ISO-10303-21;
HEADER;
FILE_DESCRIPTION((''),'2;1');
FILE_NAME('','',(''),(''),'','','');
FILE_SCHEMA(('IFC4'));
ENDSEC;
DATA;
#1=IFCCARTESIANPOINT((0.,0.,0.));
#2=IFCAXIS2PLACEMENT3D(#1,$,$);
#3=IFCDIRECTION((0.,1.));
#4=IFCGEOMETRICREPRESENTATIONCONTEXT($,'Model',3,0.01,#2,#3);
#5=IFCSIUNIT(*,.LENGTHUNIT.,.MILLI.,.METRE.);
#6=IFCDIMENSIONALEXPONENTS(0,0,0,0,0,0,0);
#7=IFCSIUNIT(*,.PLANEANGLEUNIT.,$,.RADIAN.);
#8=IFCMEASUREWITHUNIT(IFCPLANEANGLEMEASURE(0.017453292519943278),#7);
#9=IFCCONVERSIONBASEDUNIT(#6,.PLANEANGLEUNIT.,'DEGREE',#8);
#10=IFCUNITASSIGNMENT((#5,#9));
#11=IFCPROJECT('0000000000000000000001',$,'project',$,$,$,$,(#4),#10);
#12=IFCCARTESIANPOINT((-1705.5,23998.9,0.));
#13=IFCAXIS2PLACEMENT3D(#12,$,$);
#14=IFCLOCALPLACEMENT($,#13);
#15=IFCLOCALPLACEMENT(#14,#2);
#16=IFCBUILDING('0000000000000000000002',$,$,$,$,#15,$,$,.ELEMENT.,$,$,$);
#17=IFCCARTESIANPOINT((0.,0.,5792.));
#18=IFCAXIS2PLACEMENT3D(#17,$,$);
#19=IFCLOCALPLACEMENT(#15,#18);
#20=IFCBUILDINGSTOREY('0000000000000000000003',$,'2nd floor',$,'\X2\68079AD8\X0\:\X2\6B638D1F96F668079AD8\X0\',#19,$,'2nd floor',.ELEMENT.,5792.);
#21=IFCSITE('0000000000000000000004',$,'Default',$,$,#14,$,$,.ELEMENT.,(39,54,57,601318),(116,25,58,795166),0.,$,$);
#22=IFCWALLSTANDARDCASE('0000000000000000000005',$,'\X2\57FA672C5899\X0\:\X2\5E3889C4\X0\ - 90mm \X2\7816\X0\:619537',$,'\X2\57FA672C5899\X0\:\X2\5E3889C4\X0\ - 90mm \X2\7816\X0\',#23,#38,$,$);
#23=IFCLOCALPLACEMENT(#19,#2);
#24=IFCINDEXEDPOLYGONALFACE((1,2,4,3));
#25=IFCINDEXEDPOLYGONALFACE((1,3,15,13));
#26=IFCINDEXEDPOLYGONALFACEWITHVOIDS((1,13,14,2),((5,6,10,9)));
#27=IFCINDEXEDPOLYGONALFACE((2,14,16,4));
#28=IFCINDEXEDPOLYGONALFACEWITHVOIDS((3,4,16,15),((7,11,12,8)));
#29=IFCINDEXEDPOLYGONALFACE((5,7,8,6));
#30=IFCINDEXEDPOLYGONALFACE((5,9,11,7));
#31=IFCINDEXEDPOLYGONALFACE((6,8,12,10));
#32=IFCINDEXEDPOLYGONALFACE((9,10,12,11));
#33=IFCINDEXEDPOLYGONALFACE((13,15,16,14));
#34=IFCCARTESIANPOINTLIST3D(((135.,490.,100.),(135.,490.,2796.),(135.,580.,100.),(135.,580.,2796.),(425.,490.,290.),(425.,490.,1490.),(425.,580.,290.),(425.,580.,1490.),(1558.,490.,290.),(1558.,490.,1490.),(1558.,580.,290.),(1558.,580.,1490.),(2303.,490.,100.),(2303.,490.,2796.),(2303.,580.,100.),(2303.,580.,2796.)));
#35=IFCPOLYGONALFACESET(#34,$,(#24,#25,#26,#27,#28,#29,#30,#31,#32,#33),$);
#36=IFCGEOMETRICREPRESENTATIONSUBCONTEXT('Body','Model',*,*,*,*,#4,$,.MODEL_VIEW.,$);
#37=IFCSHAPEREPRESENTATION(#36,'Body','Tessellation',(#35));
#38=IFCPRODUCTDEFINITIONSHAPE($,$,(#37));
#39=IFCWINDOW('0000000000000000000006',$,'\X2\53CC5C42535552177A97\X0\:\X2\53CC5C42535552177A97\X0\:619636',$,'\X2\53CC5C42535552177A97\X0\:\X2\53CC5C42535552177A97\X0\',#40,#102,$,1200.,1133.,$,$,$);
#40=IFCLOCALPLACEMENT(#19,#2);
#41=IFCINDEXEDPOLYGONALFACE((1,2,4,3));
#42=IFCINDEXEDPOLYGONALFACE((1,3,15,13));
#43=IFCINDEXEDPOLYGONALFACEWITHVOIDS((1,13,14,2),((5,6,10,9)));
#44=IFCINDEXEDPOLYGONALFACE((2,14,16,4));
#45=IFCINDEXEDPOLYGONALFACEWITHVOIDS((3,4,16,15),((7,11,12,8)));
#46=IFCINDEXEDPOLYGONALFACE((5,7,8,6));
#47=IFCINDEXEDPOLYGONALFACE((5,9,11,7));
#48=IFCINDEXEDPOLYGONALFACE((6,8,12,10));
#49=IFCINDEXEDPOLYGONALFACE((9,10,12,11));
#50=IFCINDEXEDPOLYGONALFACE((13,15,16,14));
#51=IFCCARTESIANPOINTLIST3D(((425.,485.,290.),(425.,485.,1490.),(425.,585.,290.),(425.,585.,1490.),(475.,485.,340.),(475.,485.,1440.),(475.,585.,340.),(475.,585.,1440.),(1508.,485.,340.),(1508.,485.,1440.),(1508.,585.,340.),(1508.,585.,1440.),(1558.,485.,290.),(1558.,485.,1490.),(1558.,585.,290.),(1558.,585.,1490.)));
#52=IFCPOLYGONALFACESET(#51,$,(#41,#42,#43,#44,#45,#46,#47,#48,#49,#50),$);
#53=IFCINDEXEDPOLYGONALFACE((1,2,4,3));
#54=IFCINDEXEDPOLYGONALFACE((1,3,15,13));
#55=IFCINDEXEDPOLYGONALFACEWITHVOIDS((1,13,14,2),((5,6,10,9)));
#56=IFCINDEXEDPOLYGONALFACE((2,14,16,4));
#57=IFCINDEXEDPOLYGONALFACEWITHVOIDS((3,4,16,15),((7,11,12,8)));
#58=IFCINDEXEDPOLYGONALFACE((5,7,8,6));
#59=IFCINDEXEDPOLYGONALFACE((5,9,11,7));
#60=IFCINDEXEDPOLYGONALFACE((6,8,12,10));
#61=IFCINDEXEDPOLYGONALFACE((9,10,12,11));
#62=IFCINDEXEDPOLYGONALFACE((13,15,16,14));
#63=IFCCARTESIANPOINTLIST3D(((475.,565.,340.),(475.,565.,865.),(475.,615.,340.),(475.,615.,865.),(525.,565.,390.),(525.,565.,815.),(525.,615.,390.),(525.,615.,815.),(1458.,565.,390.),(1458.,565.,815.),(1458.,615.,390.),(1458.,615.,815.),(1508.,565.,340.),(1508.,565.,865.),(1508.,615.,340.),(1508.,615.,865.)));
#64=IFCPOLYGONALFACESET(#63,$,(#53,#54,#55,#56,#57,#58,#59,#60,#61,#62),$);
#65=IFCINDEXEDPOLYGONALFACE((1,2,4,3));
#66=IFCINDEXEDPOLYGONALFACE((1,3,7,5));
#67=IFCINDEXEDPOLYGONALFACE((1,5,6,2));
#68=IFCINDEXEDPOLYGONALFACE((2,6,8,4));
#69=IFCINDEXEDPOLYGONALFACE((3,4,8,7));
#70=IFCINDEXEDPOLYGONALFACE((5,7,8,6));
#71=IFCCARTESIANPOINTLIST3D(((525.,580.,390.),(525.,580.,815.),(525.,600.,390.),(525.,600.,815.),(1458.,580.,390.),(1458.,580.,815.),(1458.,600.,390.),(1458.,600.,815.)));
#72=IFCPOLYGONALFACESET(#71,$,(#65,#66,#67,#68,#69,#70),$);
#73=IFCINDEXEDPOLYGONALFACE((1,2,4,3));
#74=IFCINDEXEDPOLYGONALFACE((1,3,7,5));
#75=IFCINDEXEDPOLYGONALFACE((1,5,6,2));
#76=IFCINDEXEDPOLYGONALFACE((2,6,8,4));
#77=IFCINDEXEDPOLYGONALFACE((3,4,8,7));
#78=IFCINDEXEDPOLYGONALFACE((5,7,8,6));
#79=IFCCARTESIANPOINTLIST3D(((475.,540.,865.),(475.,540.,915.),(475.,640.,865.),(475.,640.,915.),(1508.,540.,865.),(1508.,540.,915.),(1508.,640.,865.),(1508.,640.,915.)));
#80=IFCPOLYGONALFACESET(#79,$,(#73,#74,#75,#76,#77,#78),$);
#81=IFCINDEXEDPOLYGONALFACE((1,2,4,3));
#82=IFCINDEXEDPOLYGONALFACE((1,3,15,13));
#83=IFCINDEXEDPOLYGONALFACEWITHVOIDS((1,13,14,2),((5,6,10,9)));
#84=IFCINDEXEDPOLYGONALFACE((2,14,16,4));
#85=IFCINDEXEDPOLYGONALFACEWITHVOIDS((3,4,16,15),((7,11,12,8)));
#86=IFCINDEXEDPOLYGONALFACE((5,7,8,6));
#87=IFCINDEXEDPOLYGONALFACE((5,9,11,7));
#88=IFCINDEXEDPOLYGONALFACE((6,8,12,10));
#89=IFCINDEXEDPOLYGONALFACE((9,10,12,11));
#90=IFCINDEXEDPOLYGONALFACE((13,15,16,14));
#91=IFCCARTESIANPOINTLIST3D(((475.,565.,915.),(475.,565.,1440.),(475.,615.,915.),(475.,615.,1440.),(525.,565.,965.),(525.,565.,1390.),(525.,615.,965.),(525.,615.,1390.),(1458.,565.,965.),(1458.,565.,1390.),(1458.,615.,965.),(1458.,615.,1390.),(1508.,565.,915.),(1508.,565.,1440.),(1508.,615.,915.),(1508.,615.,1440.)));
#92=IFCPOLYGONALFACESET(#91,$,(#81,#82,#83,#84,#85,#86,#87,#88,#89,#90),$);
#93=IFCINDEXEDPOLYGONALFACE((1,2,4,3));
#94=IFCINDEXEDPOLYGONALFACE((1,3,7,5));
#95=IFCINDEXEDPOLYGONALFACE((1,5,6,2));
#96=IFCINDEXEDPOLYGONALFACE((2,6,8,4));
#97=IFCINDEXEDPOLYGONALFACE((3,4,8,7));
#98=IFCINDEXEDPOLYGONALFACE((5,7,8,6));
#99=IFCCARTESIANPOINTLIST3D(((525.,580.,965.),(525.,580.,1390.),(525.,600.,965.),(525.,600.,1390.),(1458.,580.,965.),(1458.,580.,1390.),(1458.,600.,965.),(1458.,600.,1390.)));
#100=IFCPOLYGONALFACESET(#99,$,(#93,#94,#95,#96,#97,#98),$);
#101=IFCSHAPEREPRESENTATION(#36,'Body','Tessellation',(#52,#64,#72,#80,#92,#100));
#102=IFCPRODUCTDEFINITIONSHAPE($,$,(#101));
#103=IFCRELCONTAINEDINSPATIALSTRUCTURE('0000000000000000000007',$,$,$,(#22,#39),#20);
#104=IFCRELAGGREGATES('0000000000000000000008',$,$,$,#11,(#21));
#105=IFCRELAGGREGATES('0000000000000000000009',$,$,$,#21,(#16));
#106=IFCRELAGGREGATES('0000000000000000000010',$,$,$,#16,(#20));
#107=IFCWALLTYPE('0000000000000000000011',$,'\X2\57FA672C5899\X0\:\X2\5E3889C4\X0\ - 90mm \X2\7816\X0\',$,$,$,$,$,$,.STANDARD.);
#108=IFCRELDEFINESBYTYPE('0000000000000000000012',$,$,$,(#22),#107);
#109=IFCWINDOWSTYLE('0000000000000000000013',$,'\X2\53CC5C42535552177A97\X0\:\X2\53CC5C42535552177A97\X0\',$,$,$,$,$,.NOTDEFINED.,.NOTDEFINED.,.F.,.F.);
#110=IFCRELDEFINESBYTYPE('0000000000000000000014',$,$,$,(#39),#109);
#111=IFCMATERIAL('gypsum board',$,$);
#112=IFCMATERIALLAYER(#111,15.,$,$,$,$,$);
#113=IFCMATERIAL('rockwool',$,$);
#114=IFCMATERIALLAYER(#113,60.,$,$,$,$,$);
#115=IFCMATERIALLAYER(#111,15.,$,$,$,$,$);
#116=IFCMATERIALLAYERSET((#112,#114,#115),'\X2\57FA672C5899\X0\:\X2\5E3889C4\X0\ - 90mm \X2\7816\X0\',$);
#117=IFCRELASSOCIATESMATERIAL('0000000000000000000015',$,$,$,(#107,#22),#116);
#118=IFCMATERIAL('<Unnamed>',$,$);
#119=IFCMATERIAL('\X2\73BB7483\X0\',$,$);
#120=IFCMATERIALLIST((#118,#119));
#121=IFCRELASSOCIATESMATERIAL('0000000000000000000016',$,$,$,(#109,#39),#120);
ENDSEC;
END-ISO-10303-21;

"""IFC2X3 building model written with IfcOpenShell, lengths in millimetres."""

from ifc_helpers import new_model, entity, si_unit, converted_unit, direction, frame, frame_2d, origin, origin_2d_with_axis, place, context, subcontext, project, spatial, polyline, rectangle, outline, extrude, source, transform, mapped, material, material_list, layer, layer_set, layer_usage, type_object, type_shapes, element, fill, save


model = new_model("IFC2X3")

# Units and contexts
model_context = context("Model", 3, precision=0.01, world=origin(), true_north=direction((0.0, 1.0)))
body_context = subcontext(model_context, "Body", "Model", "MODEL_VIEW")
ifc_project = project(units=[si_unit("LENGTHUNIT", "METRE", prefix="MILLI"), converted_unit("PLANEANGLEUNIT", "DEGREE", entity("IfcPlaneAngleMeasure", 0.017453292519943278), si_unit("PLANEANGLEUNIT", "RADIAN"), dimensions=[0, 0, 0, 0, 0, 0, 0])], contexts=[model_context])

# Site, building, storey
site_placement = place(None, frame((-1705.5, 23998.9, 0.0)))
site = spatial("IfcSite", under=ifc_project, at=site_placement, Name="Default", CompositionType="ELEMENT", RefLatitude=(39, 54, 57, 601318), RefLongitude=(116, 25, 58, 795166), RefElevation=0.0)
building_placement = place(site_placement, origin())
building = spatial("IfcBuilding", under=site, at=building_placement, CompositionType="ELEMENT")
storey_placement = place(building_placement, frame((0.0, 0.0, 5792.0)))
storey = spatial("IfcBuildingStorey", under=building, at=storey_placement, Name="2nd floor", ObjectType="标高:正负零标高", LongName="2nd floor", CompositionType="ELEMENT", Elevation=5792.0)

# Wall, opening, window
ifc_material_1 = material(Name="gypsum board")
ifc_layer_1 = layer(ifc_material_1, 15.0)
ifc_material_2 = material(Name="rockwool")
ifc_layer_2 = layer(ifc_material_2, 60.0)
ifc_layer_3 = layer(ifc_material_1, 15.0)
ifc_layer_set = layer_set([ifc_layer_1, ifc_layer_2, ifc_layer_3], Name="基本墙:常规 - 90mm 砖")
ifc_layer_usage = layer_usage(ifc_layer_set, "AXIS2", "NEGATIVE", 45.0)
wall_type = type_object("IfcWallType", Name="基本墙:常规 - 90mm 砖", PredefinedType="STANDARD", material=ifc_layer_set)
wall_placement = place(storey_placement, frame((2303.0, 535.0, 100.0), z_axis=(0.0, 0.0, 1.0), x_axis=(-1.0, 0.0, 0.0)))
wall = element("IfcWallStandardCase", 1, at=wall_placement, inside=storey, type_object=wall_type, material=ifc_layer_usage, Name="基本墙:常规 - 90mm 砖:619537", ObjectType="基本墙:常规 - 90mm 砖", context=body_context, shape_type="SweptSolid", body=[
    extrude(rectangle(XDim=2168.0, YDim=90.0, at=frame_2d((1084.0, 0.0), x_axis=(-1.0, 0.0))), origin(), (0.0, 0.0, 1.0), 2696.0),
])
opening_1_placement = place(wall_placement, frame((1878.0, 45.0, 190.0)))
opening_1 = element("IfcOpeningElement", 2, at=opening_1_placement, cuts=wall, ObjectType="Opening", context=body_context, shape_type="SweptSolid", body=[
    extrude(rectangle(XDim=1200.0, YDim=1133.0, at=frame_2d((600.0, 566.5), x_axis=(1.0, 0.0))), frame((0.0, 0.0, 0.0), z_axis=(0.0, -1.0, 0.0), x_axis=(0.0, 0.0, 1.0)), (0.0, 0.0, 1.0), 90.0),
])
ifc_material_3 = material(Name="<Unnamed>")
ifc_material_4 = material(Name="玻璃")
ifc_material_list = material_list([ifc_material_3, ifc_material_4])
window_style = type_object("IfcWindowStyle", Name="双层单列窗:双层单列窗", ConstructionType="NOTDEFINED", OperationType="NOTDEFINED", ParameterTakesPrecedence=False, Sizeable=False, material=ifc_material_list)
shared_shape = source(origin(), body_context, "Body", "SweptSolid", [
    extrude(outline(polyline([(-600.0, -566.5), (600.0, -566.5), (600.0, 566.5), (-600.0, 566.5), (-600.0, -566.5)]), holes=[polyline([(-550.0, 516.5), (550.0, 516.5), (550.0, -516.5), (-550.0, -516.5), (-550.0, 516.5)])]), frame((566.5, 95.0, 600.0), z_axis=(0.0, -1.0, 0.0), x_axis=(0.0, 0.0, -1.0)), (0.0, 0.0, 1.0), 100.0),
    extrude(outline(polyline([(-262.5, -516.5), (262.5, -516.5), (262.5, 516.5), (-262.5, 516.5), (-262.5, -516.5)]), holes=[polyline([(-212.5, -466.5), (-212.5, 466.5), (212.5, 466.5), (212.5, -466.5), (-212.5, -466.5)])]), frame((566.5, 125.0, 312.5), z_axis=(0.0, -1.0, 0.0), x_axis=(0.0, 0.0, -1.0)), (0.0, 0.0, 1.0), 50.0),
    extrude(rectangle(XDim=933.0, YDim=20.0, at=origin_2d_with_axis()), frame((566.5, 100.0, 100.0)), (0.0, 0.0, 1.0), 425.0),
    extrude(rectangle(XDim=1033.0, YDim=100.0, at=origin_2d_with_axis()), frame((566.5, 100.0, 575.0)), (0.0, 0.0, 1.0), 50.0),
    extrude(outline(polyline([(-262.5, -516.5), (262.5, -516.5), (262.5, 516.5), (-262.5, 516.5), (-262.5, -516.5)]), holes=[polyline([(-212.5, -466.5), (-212.5, 466.5), (212.5, 466.5), (212.5, -466.5), (-212.5, -466.5)])]), frame((566.5, 125.0, 887.5), z_axis=(0.0, -1.0, 0.0), x_axis=(0.0, 0.0, -1.0)), (0.0, 0.0, 1.0), 50.0),
    extrude(rectangle(XDim=933.0, YDim=20.0, at=origin_2d_with_axis()), frame((566.5, 100.0, 675.0)), (0.0, 0.0, 1.0), 425.0),
])
type_shapes(window_style, [shared_shape])
window_placement = place(opening_1_placement, frame((0.0, 0.0, 0.0), z_axis=(0.0, 0.0, 1.0), x_axis=(-1.0, 0.0, 0.0)))
window = element("IfcWindow", 3, at=window_placement, inside=storey, type_object=window_style, material=ifc_material_list, Name="双层单列窗:双层单列窗:619636", ObjectType="双层单列窗:双层单列窗", OverallHeight=1200.0, OverallWidth=1133.0, context=body_context, shape_type="MappedRepresentation", body=[
    mapped(shared_shape, transform((0.0, 0.0, 0.0), scale=1.0)),
])
fill(opening_1, window)

save(model, "model.ifc")
